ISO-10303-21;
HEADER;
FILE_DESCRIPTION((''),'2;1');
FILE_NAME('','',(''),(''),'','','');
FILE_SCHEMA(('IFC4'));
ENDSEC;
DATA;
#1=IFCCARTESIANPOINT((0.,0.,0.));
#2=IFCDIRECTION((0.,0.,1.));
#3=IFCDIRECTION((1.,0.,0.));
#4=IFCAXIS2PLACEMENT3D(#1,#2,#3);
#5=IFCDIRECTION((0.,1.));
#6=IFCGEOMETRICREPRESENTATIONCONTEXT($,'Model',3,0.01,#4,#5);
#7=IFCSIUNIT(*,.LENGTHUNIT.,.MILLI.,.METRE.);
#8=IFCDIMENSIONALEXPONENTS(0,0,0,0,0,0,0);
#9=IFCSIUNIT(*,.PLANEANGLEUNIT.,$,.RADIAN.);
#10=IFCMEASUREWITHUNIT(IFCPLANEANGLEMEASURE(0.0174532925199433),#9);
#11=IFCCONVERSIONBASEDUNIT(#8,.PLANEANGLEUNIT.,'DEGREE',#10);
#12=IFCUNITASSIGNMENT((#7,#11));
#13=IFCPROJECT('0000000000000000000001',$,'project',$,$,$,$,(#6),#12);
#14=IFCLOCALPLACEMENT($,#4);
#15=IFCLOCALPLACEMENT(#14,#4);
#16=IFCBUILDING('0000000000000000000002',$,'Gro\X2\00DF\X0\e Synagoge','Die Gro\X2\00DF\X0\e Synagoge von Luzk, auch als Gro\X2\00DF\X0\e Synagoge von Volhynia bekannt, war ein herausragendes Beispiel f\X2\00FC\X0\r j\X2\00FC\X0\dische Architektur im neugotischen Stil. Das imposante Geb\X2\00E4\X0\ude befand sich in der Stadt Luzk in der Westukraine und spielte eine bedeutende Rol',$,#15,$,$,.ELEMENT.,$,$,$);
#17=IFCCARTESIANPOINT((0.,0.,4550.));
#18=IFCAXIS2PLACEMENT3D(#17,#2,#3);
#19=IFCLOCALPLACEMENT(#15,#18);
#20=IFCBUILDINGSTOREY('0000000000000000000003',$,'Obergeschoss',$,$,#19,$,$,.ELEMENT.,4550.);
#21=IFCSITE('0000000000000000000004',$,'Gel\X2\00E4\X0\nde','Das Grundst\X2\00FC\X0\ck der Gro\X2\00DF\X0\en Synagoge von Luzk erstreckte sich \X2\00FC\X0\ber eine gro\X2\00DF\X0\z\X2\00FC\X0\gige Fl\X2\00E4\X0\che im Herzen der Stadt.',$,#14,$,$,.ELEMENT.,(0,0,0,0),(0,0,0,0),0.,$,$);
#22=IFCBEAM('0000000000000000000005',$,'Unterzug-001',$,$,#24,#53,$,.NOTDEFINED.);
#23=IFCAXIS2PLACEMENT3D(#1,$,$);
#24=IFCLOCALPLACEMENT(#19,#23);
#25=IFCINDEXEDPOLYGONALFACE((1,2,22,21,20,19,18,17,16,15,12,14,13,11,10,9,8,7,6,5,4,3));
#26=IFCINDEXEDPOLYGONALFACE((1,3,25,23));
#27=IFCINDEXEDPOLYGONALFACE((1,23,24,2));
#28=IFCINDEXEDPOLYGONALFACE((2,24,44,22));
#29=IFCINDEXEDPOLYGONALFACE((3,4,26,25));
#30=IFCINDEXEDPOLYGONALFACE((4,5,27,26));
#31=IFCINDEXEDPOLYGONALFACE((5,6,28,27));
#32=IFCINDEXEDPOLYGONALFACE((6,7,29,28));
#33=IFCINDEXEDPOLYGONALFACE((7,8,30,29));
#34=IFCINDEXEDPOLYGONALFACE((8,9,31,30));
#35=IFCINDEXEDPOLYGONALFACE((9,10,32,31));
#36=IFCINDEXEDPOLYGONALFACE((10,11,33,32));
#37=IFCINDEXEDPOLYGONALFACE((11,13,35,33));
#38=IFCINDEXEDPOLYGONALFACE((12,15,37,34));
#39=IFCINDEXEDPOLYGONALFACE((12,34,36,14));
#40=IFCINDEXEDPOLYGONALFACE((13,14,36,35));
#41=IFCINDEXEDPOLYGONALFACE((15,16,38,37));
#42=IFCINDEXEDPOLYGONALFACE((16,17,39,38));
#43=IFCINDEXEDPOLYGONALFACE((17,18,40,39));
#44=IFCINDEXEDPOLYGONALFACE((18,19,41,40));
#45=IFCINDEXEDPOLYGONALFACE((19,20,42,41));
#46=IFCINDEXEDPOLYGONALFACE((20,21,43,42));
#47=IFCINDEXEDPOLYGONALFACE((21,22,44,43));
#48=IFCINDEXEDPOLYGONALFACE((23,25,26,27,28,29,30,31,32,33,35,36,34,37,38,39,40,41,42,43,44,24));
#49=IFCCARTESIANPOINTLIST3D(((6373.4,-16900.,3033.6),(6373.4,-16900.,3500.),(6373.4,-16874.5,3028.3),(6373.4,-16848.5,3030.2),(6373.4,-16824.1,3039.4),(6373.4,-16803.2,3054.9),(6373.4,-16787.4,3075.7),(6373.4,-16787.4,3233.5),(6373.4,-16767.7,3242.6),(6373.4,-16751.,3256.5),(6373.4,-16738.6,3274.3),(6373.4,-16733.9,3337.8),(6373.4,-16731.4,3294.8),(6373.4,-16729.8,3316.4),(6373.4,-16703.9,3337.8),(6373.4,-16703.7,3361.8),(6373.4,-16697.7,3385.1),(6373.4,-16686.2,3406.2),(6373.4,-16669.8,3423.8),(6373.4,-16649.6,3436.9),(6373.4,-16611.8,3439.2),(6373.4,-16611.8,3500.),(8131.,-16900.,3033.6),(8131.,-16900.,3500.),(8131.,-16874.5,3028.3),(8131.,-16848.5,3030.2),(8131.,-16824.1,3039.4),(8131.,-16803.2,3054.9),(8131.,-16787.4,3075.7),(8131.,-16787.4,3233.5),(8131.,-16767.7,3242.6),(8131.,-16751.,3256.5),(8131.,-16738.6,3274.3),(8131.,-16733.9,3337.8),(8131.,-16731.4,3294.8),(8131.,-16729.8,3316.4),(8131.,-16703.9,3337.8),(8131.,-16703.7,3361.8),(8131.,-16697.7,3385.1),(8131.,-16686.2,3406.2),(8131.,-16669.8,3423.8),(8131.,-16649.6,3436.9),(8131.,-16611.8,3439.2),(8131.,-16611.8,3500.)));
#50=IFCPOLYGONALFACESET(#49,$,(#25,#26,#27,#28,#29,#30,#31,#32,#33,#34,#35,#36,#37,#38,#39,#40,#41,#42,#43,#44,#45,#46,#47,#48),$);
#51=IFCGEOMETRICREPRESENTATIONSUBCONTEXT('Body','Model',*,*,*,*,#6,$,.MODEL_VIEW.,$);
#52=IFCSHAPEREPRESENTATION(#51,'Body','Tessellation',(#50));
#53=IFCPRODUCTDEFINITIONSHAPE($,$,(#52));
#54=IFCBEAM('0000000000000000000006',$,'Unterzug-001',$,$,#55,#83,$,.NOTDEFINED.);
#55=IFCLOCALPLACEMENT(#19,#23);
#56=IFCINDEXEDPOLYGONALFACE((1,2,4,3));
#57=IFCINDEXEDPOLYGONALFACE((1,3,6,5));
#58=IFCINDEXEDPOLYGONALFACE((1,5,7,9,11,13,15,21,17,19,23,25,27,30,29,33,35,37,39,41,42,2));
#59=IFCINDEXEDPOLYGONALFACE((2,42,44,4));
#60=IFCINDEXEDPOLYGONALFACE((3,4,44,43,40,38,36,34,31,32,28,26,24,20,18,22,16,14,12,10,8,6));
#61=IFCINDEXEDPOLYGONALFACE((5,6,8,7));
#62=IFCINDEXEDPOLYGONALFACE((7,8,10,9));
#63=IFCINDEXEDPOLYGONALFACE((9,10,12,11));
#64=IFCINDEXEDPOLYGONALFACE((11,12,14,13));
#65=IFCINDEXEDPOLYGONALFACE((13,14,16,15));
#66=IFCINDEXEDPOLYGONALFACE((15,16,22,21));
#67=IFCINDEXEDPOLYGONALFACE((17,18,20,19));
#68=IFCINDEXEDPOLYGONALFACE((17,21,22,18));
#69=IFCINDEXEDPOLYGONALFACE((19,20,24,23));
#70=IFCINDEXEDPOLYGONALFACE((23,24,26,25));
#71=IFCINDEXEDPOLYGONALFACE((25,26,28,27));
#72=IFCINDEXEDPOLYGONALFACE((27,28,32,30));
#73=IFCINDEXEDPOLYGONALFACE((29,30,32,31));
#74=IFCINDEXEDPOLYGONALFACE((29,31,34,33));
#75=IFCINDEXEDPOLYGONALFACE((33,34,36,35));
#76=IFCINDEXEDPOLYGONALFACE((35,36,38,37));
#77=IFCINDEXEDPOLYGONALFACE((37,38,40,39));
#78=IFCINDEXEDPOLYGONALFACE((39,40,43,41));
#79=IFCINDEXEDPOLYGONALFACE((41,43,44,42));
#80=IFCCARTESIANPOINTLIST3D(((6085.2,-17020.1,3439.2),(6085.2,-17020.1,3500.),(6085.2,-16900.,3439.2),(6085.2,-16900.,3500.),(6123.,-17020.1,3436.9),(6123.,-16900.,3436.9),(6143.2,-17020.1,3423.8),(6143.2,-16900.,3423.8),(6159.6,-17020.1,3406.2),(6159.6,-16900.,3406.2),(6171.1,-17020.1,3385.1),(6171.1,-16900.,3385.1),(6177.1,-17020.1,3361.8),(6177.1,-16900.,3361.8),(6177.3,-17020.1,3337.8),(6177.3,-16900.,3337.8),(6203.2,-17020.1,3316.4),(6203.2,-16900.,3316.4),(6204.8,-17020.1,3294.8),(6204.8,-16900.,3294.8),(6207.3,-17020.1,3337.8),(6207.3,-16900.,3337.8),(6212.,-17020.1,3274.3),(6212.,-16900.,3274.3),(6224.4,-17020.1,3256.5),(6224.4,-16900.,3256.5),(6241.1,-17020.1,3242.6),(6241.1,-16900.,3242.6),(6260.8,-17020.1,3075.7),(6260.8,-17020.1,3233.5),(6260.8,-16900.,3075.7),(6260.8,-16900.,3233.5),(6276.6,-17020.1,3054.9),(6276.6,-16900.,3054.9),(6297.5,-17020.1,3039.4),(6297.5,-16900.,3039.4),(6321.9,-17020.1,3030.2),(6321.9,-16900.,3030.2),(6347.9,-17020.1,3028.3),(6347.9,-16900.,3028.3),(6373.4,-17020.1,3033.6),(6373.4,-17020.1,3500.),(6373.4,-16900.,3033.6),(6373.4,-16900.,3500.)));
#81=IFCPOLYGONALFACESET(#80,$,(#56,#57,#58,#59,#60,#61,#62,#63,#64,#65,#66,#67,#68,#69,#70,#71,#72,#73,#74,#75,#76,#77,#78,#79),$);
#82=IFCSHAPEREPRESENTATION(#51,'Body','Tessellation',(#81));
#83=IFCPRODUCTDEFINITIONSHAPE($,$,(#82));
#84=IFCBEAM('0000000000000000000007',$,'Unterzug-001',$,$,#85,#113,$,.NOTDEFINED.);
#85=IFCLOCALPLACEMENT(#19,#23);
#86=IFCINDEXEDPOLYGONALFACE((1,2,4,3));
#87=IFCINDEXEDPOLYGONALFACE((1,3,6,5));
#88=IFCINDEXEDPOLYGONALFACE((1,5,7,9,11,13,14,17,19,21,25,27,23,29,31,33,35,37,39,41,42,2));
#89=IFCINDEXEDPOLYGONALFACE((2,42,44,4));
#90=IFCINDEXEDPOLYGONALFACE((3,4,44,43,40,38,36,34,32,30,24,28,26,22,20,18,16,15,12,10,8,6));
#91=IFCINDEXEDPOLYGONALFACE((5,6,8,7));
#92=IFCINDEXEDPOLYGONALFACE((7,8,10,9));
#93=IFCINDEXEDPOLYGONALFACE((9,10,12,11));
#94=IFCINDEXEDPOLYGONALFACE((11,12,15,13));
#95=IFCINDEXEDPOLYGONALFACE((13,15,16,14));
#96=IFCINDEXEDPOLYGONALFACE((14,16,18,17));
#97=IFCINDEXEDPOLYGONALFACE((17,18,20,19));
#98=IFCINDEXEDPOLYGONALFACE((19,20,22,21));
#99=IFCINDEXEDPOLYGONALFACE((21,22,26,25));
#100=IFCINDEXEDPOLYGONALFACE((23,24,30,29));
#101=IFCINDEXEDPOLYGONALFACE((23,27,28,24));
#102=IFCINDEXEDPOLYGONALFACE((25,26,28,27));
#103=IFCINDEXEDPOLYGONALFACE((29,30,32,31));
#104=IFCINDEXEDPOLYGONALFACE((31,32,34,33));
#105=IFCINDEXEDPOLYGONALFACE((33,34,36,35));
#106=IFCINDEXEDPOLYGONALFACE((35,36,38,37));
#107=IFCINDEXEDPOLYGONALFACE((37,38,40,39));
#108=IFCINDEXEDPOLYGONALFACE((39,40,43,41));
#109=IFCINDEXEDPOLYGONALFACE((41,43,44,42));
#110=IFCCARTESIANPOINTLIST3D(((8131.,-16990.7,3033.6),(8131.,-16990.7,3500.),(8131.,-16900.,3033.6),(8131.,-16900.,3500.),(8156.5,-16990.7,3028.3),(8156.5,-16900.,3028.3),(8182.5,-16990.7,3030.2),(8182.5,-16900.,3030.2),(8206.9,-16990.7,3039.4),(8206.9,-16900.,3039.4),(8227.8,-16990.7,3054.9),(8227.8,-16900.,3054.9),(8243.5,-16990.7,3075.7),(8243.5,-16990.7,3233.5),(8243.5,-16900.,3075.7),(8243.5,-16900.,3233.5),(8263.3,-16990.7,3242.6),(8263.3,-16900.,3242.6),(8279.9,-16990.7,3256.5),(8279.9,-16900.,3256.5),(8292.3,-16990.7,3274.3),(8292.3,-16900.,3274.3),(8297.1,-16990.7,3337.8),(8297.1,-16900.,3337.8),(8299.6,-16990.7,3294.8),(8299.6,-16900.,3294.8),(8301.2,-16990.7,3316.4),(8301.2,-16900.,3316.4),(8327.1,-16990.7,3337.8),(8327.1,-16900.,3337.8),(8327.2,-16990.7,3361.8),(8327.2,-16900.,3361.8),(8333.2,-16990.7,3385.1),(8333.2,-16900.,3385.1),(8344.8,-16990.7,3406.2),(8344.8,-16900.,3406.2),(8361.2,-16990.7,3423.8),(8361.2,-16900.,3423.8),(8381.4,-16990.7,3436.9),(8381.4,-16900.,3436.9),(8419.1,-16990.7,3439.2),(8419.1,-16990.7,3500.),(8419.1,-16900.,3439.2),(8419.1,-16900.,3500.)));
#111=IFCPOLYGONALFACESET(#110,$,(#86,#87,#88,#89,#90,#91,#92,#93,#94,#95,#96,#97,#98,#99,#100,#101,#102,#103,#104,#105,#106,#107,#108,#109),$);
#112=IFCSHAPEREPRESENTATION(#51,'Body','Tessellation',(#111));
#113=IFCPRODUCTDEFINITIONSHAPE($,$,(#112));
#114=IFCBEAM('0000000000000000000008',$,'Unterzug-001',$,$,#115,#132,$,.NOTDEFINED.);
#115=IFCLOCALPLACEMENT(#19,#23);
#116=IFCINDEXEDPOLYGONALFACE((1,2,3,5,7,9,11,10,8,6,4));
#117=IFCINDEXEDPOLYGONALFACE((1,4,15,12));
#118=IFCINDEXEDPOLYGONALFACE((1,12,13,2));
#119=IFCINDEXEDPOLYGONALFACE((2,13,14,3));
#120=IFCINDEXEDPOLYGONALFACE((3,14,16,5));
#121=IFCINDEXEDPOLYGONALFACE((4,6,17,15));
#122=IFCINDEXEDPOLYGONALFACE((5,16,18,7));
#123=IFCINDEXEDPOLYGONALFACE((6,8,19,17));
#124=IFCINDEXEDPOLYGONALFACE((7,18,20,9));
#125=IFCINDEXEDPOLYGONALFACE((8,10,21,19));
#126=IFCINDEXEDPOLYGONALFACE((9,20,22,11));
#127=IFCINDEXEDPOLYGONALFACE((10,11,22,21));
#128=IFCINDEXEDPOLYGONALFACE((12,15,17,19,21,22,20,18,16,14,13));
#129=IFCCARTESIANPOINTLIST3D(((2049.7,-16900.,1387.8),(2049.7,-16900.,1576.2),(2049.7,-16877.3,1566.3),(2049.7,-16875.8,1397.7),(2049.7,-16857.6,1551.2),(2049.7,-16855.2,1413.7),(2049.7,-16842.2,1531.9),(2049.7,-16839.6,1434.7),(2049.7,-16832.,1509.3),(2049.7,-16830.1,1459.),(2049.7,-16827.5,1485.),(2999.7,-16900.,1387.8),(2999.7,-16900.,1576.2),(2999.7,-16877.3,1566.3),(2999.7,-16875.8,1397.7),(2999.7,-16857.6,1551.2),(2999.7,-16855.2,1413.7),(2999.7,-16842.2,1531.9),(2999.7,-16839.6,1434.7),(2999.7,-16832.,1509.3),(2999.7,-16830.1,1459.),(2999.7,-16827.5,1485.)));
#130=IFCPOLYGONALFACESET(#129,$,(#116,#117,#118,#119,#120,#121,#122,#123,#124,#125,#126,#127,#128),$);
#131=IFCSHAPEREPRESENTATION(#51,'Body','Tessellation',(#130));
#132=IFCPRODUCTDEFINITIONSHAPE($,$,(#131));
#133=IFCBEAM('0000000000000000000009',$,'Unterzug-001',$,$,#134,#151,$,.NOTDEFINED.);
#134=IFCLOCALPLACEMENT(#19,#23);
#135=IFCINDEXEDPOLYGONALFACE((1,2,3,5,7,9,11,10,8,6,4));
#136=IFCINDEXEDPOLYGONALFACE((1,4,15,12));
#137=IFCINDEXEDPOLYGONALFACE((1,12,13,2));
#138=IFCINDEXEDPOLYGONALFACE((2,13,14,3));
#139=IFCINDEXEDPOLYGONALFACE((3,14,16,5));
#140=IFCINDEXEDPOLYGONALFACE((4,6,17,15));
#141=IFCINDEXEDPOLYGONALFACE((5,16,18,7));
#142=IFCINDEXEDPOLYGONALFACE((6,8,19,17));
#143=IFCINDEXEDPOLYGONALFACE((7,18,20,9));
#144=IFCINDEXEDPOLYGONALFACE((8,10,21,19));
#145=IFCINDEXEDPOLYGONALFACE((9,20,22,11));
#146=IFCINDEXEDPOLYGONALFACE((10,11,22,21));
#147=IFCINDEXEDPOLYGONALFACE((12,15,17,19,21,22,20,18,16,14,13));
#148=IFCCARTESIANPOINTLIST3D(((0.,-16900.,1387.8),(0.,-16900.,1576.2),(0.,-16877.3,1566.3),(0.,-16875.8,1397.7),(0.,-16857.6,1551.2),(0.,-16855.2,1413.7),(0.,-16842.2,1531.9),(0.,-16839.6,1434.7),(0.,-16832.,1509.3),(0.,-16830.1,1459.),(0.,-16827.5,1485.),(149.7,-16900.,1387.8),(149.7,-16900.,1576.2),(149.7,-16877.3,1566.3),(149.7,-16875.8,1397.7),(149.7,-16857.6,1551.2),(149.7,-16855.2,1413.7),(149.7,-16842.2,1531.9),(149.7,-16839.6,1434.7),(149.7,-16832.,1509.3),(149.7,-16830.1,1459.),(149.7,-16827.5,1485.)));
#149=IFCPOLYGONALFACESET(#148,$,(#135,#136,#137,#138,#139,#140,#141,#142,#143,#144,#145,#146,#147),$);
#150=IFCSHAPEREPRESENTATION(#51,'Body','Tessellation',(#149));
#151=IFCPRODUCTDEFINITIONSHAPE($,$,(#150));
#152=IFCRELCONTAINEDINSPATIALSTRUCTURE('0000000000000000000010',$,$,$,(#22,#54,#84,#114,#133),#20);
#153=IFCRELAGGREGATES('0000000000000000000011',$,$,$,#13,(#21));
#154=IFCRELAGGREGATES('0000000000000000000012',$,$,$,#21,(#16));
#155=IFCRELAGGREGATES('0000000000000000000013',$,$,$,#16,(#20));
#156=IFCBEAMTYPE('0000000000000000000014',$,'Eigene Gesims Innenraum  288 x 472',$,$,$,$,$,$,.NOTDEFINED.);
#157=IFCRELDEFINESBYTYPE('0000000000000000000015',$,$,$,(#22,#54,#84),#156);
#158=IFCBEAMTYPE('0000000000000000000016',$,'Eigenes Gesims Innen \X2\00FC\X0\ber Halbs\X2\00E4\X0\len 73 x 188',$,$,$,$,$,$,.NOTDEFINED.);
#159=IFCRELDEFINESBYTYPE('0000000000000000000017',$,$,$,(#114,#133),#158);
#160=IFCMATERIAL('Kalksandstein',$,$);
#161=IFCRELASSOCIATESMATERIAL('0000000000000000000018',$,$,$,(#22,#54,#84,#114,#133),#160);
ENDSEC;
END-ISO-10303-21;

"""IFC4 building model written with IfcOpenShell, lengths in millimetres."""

from ifc_helpers import new_model, entity, si_unit, converted_unit, direction, frame, origin_with_axes, place, context, subcontext, project, spatial, line, arc, indexed_curve, outline, extrude, material, material_profile, profile_set, type_object, element, save


model = new_model("IFC4")

# Units and contexts
model_context = context("Model", 3, precision=0.01, world=origin_with_axes(), true_north=direction((0.0, 1.0)))
body_context = subcontext(model_context, "Body", "Model", "MODEL_VIEW")
ifc_project = project(units=[si_unit("LENGTHUNIT", "METRE", prefix="MILLI"), converted_unit("PLANEANGLEUNIT", "DEGREE", entity("IfcPlaneAngleMeasure", 0.0174532925199433), si_unit("PLANEANGLEUNIT", "RADIAN"), dimensions=[0, 0, 0, 0, 0, 0, 0])], contexts=[model_context])

# Site, building, storey
site_placement = place(None, origin_with_axes())
site = spatial("IfcSite", under=ifc_project, at=site_placement, Name="Gelände", Description="Das Grundstück der Großen Synagoge von Luzk erstreckte sich über eine großzügige Fläche im Herzen der Stadt.", CompositionType="ELEMENT", RefLatitude=(0, 0, 0, 0), RefLongitude=(0, 0, 0, 0), RefElevation=0.0)
building_placement = place(site_placement, origin_with_axes())
building = spatial("IfcBuilding", under=site, at=building_placement, Name="Große Synagoge", Description="Die Große Synagoge von Luzk, auch als Große Synagoge von Volhynia bekannt, war ein herausragendes Beispiel für jüdische Architektur im neugotischen Stil. Das imposante Gebäude befand sich in der Stadt Luzk in der Westukraine und spielte eine bedeutende Rol", CompositionType="ELEMENT")
storey_placement = place(building_placement, frame((0.0, 0.0, 4550.0), z_axis=(0.0, 0.0, 1.0), x_axis=(1.0, 0.0, 0.0)))
storey = spatial("IfcBuildingStorey", under=building, at=storey_placement, Name="Obergeschoss", CompositionType="ELEMENT", Elevation=4550.0)

# Beams
ifc_material_1 = material(Name="Kalksandstein")
ifc_material_profile_1 = material_profile(ifc_material_1, outline(indexed_curve([(0.0, 0.0), (0.0, -466.4), (64.0, -466.1), (112.6, -424.3), (112.6, -266.5), (161.4, -225.7), (166.1, -162.2), (196.1, -162.2), (207.4, -104.0), (250.4, -63.1), (288.2, -60.8), (288.2, 0.0)], segments=[line(1, 2), arc(2, 3, 4), line(4, 5), arc(5, 6, 7), line(7, 8), arc(8, 9, 10), line(10, 11, 12, 1)])), Name="Kalksandstein")
ifc_profile_set_1 = profile_set([ifc_material_profile_1], Name="Eigene Gesims Innenraum ")
beam_type_1 = type_object("IfcBeamType", Name="Eigene Gesims Innenraum  288 x 472", PredefinedType="NOTDEFINED")
beam_1_placement = place(storey_placement, frame((6373.4, -16900.0, 3500.0), z_axis=(0.0, 0.0, 1.0), x_axis=(0.0, -1.0, 0.0)))
element("IfcBeam", 1, at=beam_1_placement, inside=storey, type_object=beam_type_1, material=ifc_profile_set_1, Name="Unterzug-001", PredefinedType="NOTDEFINED", context=body_context, shape_type="SweptSolid", body=[
    extrude(outline(indexed_curve([(0.0, 0.0), (0.0, -466.4), (64.0, -466.1), (112.6, -424.3), (112.6, -266.5), (161.4, -225.7), (166.1, -162.2), (196.1, -162.2), (207.4, -104.0), (250.4, -63.1), (288.2, -60.8), (288.2, 0.0)], segments=[line(1, 2), arc(2, 3, 4), line(4, 5), arc(5, 6, 7), line(7, 8), arc(8, 9, 10), line(10, 11, 12, 1)])), frame((0.0, 1757.6, 0.0), z_axis=(0.0, 1.0, 0.0), x_axis=(-1.0, 0.0, 0.0)), (0.0, 0.0, -1.0), 1757.6),
])
beam_2_placement = place(storey_placement, frame((6373.4, -16900.0, 3500.0), z_axis=(0.0, 0.0, 1.0), x_axis=(-1.0, 0.0, 0.0)))
element("IfcBeam", 2, at=beam_2_placement, inside=storey, type_object=beam_type_1, material=ifc_profile_set_1, Name="Unterzug-001", PredefinedType="NOTDEFINED", context=body_context, shape_type="SweptSolid", body=[
    extrude(outline(indexed_curve([(0.0, 0.0), (0.0, -466.4), (64.0, -466.1), (112.6, -424.3), (112.6, -266.5), (161.4, -225.7), (166.1, -162.2), (196.1, -162.2), (207.4, -104.0), (250.4, -63.1), (288.2, -60.8), (288.2, 0.0)], segments=[line(1, 2), arc(2, 3, 4), line(4, 5), arc(5, 6, 7), line(7, 8), arc(8, 9, 10), line(10, 11, 12, 1)])), frame((0.0, 120.1, 0.0), z_axis=(0.0, -1.0, 0.0), x_axis=(1.0, 0.0, 0.0)), (0.0, 0.0, 1.0), 120.1),
])
beam_3_placement = place(storey_placement, frame((8131.0, -16900.0, 3500.0), z_axis=(0.0, 0.0, 1.0), x_axis=(-1.0, 0.0, 0.0)))
element("IfcBeam", 3, at=beam_3_placement, inside=storey, type_object=beam_type_1, material=ifc_profile_set_1, Name="Unterzug-001", PredefinedType="NOTDEFINED", context=body_context, shape_type="SweptSolid", body=[
    extrude(outline(indexed_curve([(0.0, 0.0), (0.0, -466.4), (64.0, -466.1), (112.6, -424.3), (112.6, -266.5), (161.4, -225.7), (166.1, -162.2), (196.1, -162.2), (207.4, -104.0), (250.4, -63.1), (288.2, -60.8), (288.2, 0.0)], segments=[line(1, 2), arc(2, 3, 4), line(4, 5), arc(5, 6, 7), line(7, 8), arc(8, 9, 10), line(10, 11, 12, 1)])), frame((0.0, 90.7, 0.0), z_axis=(0.0, 1.0, 0.0), x_axis=(-1.0, 0.0, 0.0)), (0.0, 0.0, -1.0), 90.7),
])
ifc_material_profile_2 = material_profile(ifc_material_1, outline(indexed_curve([(72.5, -91.2), (50.7, -34.1), (0.0, 0.0), (0.0, -188.3), (53.3, -152.5)], segments=[arc(1, 2, 3), line(3, 4), arc(4, 5, 1)])), Name="Kalksandstein")
ifc_profile_set_2 = profile_set([ifc_material_profile_2], Name="Eigenes Gesims Innen über Halbsälen")
beam_type_2 = type_object("IfcBeamType", Name="Eigenes Gesims Innen über Halbsälen 73 x 188", PredefinedType="NOTDEFINED")
beam_4_placement = place(storey_placement, frame((2049.7, -16900.0, 1576.2), z_axis=(0.0, 0.0, 1.0), x_axis=(0.0, -1.0, 0.0)))
element("IfcBeam", 4, at=beam_4_placement, inside=storey, type_object=beam_type_2, material=ifc_profile_set_2, Name="Unterzug-001", PredefinedType="NOTDEFINED", context=body_context, shape_type="SweptSolid", body=[
    extrude(outline(indexed_curve([(72.5, -91.2), (50.7, -34.1), (0.0, 0.0), (0.0, -188.3), (53.3, -152.5)], segments=[arc(1, 2, 3), line(3, 4), arc(4, 5, 1)])), frame((0.0, 950.0, 0.0), z_axis=(0.0, 1.0, 0.0), x_axis=(-1.0, 0.0, 0.0)), (0.0, 0.0, -1.0), 950.0),
])
beam_5_placement = place(storey_placement, frame((0.0, -16900.0, 1576.2), z_axis=(0.0, 0.0, 1.0), x_axis=(0.0, -1.0, 0.0)))
element("IfcBeam", 5, at=beam_5_placement, inside=storey, type_object=beam_type_2, material=ifc_profile_set_2, Name="Unterzug-001", PredefinedType="NOTDEFINED", context=body_context, shape_type="SweptSolid", body=[
    extrude(outline(indexed_curve([(72.5, -91.2), (50.7, -34.1), (0.0, 0.0), (0.0, -188.3), (53.3, -152.5)], segments=[arc(1, 2, 3), line(3, 4), arc(4, 5, 1)])), frame((0.0, 149.7, 0.0), z_axis=(0.0, 1.0, 0.0), x_axis=(-1.0, 0.0, 0.0)), (0.0, 0.0, -1.0), 149.7),
])

save(model, "model.ifc")
